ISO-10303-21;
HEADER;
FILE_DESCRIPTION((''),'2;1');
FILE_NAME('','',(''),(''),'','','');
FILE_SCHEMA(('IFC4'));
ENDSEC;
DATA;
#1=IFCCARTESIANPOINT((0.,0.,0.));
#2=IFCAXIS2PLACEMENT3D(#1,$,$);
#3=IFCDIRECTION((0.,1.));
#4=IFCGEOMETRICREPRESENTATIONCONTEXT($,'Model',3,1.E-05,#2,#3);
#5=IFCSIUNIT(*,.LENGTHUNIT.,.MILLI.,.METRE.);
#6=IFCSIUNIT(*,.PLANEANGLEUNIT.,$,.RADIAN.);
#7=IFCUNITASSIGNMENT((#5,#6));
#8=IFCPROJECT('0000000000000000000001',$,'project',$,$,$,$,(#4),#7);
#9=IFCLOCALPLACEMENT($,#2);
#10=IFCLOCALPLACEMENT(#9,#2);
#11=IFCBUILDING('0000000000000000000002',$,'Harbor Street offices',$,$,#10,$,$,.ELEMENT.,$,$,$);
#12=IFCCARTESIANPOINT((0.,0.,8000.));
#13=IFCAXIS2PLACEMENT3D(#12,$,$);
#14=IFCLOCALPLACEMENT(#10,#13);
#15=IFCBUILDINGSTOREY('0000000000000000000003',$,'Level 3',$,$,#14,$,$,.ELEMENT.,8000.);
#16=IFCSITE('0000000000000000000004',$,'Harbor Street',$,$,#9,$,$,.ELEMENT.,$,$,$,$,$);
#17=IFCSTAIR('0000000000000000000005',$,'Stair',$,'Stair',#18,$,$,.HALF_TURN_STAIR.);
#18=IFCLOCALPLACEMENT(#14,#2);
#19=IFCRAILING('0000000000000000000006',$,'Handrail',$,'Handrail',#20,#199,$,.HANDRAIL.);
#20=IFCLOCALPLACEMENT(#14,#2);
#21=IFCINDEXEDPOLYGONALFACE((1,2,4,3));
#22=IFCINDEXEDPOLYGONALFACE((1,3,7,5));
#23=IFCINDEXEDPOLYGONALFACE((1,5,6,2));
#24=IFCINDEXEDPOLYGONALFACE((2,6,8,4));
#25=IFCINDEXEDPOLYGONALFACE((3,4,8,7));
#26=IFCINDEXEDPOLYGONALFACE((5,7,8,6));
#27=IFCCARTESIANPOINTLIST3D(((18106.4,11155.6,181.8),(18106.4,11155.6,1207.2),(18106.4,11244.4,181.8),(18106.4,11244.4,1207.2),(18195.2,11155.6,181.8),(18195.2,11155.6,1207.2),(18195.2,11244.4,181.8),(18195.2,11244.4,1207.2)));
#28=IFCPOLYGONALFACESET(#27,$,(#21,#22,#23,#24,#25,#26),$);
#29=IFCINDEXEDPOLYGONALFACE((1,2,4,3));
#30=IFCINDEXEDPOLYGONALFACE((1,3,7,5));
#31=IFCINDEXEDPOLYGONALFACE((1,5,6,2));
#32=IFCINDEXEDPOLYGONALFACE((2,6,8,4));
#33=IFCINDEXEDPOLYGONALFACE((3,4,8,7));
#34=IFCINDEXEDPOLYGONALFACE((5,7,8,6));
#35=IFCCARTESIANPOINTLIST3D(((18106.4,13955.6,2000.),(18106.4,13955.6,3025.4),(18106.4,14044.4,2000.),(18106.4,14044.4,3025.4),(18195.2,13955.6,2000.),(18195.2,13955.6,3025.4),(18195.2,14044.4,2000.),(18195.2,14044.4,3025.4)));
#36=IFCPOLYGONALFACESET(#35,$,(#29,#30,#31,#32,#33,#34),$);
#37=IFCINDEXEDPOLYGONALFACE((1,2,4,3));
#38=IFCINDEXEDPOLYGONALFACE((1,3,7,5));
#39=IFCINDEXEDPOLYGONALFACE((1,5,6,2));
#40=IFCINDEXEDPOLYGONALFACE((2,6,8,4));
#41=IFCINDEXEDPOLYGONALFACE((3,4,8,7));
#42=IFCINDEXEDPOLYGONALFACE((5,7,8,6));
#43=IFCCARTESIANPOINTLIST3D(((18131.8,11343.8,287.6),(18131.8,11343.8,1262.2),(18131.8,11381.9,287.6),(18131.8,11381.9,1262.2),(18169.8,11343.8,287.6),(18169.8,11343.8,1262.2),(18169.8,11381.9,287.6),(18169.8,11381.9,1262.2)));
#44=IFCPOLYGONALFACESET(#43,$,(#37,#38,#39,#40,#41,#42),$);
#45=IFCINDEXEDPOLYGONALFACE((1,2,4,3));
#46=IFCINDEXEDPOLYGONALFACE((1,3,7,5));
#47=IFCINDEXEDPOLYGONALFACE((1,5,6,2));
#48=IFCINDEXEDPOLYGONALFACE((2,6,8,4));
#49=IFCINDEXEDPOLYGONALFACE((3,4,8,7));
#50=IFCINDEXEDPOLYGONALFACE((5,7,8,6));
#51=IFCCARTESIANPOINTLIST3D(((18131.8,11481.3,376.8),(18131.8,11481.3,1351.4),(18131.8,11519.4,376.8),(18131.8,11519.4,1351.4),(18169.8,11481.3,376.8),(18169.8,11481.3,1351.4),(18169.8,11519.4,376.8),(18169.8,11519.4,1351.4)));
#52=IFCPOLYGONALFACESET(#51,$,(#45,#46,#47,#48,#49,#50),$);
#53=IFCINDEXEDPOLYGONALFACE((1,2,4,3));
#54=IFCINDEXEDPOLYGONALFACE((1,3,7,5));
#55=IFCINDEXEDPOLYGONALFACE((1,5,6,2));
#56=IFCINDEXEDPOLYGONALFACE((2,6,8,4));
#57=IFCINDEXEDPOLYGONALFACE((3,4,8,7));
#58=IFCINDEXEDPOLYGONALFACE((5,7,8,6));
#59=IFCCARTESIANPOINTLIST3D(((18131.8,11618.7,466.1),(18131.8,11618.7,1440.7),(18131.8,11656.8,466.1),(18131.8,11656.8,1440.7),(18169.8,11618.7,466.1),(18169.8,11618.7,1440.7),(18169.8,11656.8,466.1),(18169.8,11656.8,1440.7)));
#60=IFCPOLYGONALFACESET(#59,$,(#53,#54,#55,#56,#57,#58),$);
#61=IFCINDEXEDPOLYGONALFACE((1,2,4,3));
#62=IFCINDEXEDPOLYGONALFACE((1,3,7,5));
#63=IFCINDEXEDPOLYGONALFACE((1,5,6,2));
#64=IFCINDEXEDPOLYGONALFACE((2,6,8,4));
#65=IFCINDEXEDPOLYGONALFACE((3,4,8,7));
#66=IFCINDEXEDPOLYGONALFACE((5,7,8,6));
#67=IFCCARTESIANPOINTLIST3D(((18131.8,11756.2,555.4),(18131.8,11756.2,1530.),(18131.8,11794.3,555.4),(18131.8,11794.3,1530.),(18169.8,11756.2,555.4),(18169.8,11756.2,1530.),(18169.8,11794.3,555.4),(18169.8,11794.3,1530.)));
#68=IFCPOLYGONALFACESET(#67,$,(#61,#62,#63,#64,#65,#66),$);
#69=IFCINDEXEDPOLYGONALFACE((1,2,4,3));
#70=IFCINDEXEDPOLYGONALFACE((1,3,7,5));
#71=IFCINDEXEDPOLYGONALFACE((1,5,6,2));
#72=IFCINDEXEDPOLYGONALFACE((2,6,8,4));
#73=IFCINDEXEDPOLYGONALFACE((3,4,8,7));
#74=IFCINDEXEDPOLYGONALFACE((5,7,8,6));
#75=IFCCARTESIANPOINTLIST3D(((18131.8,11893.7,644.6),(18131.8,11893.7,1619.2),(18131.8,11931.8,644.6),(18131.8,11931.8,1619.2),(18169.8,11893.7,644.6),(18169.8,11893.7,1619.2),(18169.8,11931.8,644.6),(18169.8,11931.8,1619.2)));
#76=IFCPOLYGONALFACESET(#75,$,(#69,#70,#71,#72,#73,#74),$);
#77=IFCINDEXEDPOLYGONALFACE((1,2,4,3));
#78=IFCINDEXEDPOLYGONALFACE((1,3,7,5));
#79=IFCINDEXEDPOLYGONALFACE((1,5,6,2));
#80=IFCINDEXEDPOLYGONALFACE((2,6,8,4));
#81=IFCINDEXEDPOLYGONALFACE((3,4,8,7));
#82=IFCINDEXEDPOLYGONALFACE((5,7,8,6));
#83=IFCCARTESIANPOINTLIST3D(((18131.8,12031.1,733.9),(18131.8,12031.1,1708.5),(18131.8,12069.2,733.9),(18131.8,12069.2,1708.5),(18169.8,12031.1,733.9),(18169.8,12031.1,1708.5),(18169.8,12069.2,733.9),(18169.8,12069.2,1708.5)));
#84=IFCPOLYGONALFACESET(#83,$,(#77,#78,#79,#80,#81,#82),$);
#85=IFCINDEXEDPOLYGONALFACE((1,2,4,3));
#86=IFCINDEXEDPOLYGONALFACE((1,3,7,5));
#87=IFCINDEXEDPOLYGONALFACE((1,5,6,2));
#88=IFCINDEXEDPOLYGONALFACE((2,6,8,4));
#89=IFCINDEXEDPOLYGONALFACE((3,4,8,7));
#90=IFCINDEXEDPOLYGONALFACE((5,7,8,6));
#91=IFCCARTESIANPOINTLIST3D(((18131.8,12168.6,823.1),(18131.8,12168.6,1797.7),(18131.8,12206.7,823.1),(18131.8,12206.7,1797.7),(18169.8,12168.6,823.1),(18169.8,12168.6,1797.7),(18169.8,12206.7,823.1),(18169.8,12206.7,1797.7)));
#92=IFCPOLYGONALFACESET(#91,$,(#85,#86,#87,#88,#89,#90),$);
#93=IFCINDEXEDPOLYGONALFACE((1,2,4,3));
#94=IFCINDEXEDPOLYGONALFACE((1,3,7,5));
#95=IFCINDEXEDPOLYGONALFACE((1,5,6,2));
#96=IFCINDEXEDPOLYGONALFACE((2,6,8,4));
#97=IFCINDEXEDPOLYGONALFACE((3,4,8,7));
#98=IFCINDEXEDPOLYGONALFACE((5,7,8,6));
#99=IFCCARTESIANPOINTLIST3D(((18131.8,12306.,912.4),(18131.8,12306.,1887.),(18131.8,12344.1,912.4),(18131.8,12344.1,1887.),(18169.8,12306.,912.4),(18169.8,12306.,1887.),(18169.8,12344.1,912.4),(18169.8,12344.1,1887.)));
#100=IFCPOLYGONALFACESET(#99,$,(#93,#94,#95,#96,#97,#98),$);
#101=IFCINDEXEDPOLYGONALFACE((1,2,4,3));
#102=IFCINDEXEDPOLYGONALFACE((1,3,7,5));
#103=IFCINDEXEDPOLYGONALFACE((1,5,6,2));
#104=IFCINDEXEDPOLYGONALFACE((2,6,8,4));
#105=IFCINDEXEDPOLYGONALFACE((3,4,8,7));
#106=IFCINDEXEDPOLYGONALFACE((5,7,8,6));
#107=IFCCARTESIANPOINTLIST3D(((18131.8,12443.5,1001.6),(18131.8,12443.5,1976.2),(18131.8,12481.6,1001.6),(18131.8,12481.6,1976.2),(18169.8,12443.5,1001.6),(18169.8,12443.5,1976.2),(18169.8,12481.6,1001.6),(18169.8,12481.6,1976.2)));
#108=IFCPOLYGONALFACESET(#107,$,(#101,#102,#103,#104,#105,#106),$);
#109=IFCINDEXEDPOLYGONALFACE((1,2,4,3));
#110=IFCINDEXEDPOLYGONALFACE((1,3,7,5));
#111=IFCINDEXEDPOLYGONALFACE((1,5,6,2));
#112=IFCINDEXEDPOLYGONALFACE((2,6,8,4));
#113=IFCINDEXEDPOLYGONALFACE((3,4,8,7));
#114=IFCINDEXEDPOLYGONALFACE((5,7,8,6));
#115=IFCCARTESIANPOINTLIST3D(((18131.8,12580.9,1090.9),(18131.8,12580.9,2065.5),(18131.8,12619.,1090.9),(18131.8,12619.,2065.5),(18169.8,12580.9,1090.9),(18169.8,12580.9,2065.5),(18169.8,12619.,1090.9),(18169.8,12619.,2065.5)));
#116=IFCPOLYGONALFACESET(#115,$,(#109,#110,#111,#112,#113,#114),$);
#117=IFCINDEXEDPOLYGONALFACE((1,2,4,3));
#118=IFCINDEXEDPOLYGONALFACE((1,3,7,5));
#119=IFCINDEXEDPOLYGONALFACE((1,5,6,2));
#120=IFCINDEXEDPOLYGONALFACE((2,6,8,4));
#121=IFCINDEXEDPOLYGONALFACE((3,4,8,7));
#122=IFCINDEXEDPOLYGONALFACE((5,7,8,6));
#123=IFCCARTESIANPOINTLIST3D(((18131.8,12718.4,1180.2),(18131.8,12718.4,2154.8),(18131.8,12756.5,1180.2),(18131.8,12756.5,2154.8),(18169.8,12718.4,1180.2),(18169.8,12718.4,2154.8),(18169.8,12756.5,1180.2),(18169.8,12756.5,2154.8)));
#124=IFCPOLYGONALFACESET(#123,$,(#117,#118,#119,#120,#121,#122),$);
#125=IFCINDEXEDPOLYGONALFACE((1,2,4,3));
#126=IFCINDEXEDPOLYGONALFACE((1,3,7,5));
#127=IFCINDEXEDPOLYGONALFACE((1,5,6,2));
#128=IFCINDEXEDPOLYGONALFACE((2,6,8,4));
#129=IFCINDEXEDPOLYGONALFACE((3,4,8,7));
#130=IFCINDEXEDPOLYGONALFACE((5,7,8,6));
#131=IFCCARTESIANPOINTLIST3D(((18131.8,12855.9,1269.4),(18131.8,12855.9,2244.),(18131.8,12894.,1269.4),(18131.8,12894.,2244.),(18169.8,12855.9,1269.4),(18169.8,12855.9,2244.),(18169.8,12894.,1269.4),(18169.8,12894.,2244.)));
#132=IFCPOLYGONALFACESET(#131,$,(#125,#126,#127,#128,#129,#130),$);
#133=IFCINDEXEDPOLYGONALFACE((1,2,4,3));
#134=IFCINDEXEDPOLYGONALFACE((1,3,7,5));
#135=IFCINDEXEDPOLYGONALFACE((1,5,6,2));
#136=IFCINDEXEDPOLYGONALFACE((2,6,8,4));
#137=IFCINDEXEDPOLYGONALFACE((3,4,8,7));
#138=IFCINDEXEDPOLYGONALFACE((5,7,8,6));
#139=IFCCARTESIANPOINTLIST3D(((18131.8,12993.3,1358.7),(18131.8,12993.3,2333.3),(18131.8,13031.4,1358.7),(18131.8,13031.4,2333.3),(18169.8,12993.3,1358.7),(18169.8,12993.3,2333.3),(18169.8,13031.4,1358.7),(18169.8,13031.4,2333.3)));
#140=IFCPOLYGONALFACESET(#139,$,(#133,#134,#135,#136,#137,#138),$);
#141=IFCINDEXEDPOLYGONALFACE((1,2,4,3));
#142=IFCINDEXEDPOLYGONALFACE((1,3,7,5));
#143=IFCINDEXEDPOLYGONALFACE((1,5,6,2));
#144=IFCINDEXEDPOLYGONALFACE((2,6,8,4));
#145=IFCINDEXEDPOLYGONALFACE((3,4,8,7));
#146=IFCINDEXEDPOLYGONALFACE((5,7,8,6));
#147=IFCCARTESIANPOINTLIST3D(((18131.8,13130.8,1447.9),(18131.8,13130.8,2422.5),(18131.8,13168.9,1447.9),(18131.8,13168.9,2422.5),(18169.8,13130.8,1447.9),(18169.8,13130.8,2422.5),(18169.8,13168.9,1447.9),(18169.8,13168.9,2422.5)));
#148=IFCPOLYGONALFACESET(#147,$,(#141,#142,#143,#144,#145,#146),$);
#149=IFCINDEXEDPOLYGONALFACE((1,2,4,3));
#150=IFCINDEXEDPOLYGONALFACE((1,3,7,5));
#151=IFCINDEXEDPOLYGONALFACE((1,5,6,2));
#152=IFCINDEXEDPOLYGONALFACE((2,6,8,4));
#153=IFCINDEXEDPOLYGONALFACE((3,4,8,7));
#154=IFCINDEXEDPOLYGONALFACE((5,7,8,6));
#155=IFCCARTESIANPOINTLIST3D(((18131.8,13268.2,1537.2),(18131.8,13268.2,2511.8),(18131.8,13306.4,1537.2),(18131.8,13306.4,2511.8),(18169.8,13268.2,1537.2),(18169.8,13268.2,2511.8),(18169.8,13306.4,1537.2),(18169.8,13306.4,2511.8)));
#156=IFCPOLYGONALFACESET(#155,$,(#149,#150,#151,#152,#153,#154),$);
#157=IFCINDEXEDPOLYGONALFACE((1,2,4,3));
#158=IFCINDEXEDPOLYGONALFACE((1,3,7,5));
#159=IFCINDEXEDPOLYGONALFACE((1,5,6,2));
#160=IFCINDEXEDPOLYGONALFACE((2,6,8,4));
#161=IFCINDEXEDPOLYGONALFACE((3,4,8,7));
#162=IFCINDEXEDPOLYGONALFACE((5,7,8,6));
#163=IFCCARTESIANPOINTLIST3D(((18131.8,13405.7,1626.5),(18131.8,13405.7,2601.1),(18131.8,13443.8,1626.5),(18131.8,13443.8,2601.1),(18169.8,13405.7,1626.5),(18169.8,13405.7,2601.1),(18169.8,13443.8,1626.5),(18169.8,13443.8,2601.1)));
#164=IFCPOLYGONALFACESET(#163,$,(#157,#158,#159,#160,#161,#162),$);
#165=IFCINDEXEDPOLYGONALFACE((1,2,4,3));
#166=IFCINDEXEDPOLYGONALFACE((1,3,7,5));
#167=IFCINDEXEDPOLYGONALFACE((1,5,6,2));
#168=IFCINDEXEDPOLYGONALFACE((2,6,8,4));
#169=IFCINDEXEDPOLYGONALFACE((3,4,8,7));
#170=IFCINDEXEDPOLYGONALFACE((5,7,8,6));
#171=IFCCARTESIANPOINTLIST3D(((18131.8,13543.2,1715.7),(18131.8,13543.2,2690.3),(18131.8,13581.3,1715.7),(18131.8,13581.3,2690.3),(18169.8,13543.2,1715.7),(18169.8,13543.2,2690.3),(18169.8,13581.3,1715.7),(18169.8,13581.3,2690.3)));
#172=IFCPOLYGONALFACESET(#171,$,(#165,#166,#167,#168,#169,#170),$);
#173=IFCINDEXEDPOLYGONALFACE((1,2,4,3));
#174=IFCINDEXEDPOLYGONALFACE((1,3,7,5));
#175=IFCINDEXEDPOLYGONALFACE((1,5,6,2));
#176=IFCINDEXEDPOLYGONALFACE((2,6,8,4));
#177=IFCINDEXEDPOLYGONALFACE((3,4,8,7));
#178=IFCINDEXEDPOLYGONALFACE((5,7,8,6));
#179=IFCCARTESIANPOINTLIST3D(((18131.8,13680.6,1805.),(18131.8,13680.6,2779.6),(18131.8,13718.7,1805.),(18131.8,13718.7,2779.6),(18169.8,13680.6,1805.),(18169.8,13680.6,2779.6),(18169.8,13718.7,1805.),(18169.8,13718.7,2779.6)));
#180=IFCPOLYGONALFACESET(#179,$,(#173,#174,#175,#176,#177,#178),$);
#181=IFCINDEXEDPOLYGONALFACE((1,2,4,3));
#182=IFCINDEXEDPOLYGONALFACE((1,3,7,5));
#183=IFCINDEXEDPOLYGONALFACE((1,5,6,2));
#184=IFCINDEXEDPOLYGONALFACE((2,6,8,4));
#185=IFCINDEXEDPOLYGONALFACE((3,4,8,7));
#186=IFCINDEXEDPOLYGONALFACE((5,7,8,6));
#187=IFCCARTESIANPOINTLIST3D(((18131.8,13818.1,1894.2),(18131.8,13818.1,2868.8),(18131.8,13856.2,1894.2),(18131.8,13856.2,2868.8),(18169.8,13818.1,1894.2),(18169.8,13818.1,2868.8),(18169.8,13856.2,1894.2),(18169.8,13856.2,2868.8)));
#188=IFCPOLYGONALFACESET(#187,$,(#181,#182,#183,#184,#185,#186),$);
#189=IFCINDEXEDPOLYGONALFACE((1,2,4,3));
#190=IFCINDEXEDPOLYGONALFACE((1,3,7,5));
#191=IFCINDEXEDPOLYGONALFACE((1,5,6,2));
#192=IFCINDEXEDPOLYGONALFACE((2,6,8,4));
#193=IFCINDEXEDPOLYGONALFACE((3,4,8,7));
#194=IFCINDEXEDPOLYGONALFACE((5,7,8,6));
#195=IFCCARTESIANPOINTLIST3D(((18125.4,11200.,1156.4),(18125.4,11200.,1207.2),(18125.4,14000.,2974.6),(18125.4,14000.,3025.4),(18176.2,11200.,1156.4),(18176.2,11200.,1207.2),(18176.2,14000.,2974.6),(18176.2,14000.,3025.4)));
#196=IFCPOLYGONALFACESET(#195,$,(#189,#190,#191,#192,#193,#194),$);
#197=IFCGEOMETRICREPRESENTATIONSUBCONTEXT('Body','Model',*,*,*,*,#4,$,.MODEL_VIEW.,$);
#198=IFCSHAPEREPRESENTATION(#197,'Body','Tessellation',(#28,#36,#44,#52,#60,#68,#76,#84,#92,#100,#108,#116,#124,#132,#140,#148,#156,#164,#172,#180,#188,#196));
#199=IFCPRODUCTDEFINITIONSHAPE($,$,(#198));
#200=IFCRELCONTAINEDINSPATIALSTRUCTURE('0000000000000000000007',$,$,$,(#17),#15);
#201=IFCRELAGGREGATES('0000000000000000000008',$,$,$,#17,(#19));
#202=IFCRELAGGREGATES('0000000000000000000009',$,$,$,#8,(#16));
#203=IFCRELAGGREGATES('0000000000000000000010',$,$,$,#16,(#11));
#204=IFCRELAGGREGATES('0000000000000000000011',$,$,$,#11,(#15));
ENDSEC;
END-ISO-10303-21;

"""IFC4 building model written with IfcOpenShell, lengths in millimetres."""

from ifc_helpers import new_model, si_unit, direction, frame, origin, origin_with_axes, place, context, subcontext, project, spatial, polyline, outline, extrude, element, aggregate, save


model = new_model("IFC4")

# Units and contexts
model_context = context("Model", 3, precision=1e-05, world=origin(), true_north=direction((0.0, 1.0)))
body_context = subcontext(model_context, "Body", "Model", "MODEL_VIEW")
ifc_project = project(units=[si_unit("LENGTHUNIT", "METRE", prefix="MILLI"), si_unit("PLANEANGLEUNIT", "RADIAN")], contexts=[model_context])

# Site, building, storey
site_placement = place(None, origin())
site = spatial("IfcSite", under=ifc_project, at=site_placement, Name="Harbor Street", CompositionType="ELEMENT")
building_placement = place(site_placement, origin())
building = spatial("IfcBuilding", under=site, at=building_placement, Name="Harbor Street offices", CompositionType="ELEMENT")
storey_placement = place(building_placement, frame((0.0, 0.0, 8000.0)))
storey = spatial("IfcBuildingStorey", under=building, at=storey_placement, Name="Level 3", CompositionType="ELEMENT", Elevation=8000.0)

# Stair
stair_placement = place(storey_placement, origin_with_axes())
stair = element("IfcStair", 1, at=stair_placement, inside=storey, Name="Stair", ObjectType="Stair", PredefinedType="HALF_TURN_STAIR")

# Railing
railing_1_placement = place(storey_placement, origin_with_axes())
railing_1 = element("IfcRailing", 2, at=railing_1_placement, Name="Handrail", ObjectType="Handrail", PredefinedType="HANDRAIL", context=body_context, shape_type="SweptSolid", body=[
    extrude(outline(polyline([(-44.5, -44.5), (44.5, -44.5), (44.5, 44.5), (-44.5, 44.5), (-44.5, -44.5)])), frame((18150.8, 11200.0, 181.8), z_axis=(0.0, 0.0, 1.0), x_axis=(1.0, 0.0, 0.0)), (0.0, 0.0, 1.0), 1025.4),
    extrude(outline(polyline([(-44.5, -44.5), (44.5, -44.5), (44.5, 44.5), (-44.5, 44.5), (-44.5, -44.5)])), frame((18150.8, 14000.0, 2000.0), z_axis=(0.0, 0.0, 1.0), x_axis=(1.0, 0.0, 0.0)), (0.0, 0.0, 1.0), 1025.4),
    extrude(outline(polyline([(-19.1, -19.1), (19.1, -19.1), (19.1, 19.1), (-19.1, 19.1), (-19.1, -19.1)])), frame((18150.8, 11362.9, 287.6), z_axis=(0.0, 0.0, 1.0), x_axis=(1.0, 0.0, 0.0)), (0.0, 0.0, 1.0), 974.6),
    extrude(outline(polyline([(-19.1, -19.1), (19.1, -19.1), (19.1, 19.1), (-19.1, 19.1), (-19.1, -19.1)])), frame((18150.8, 11500.3, 376.8), z_axis=(0.0, 0.0, 1.0), x_axis=(1.0, 0.0, 0.0)), (0.0, 0.0, 1.0), 974.6),
    extrude(outline(polyline([(-19.1, -19.1), (19.1, -19.1), (19.1, 19.1), (-19.1, 19.1), (-19.1, -19.1)])), frame((18150.8, 11637.8, 466.1), z_axis=(0.0, 0.0, 1.0), x_axis=(1.0, 0.0, 0.0)), (0.0, 0.0, 1.0), 974.6),
    extrude(outline(polyline([(-19.1, -19.1), (19.1, -19.1), (19.1, 19.1), (-19.1, 19.1), (-19.1, -19.1)])), frame((18150.8, 11775.2, 555.4), z_axis=(0.0, 0.0, 1.0), x_axis=(1.0, 0.0, 0.0)), (0.0, 0.0, 1.0), 974.6),
    extrude(outline(polyline([(-19.1, -19.1), (19.1, -19.1), (19.1, 19.1), (-19.1, 19.1), (-19.1, -19.1)])), frame((18150.8, 11912.7, 644.6), z_axis=(0.0, 0.0, 1.0), x_axis=(1.0, 0.0, 0.0)), (0.0, 0.0, 1.0), 974.6),
    extrude(outline(polyline([(-19.1, -19.1), (19.1, -19.1), (19.1, 19.1), (-19.1, 19.1), (-19.1, -19.1)])), frame((18150.8, 12050.2, 733.9), z_axis=(0.0, 0.0, 1.0), x_axis=(1.0, 0.0, 0.0)), (0.0, 0.0, 1.0), 974.6),
    extrude(outline(polyline([(-19.1, -19.1), (19.1, -19.1), (19.1, 19.1), (-19.1, 19.1), (-19.1, -19.1)])), frame((18150.8, 12187.6, 823.1), z_axis=(0.0, 0.0, 1.0), x_axis=(1.0, 0.0, 0.0)), (0.0, 0.0, 1.0), 974.6),
    extrude(outline(polyline([(-19.1, -19.1), (19.1, -19.1), (19.1, 19.1), (-19.1, 19.1), (-19.1, -19.1)])), frame((18150.8, 12325.1, 912.4), z_axis=(0.0, 0.0, 1.0), x_axis=(1.0, 0.0, 0.0)), (0.0, 0.0, 1.0), 974.6),
    extrude(outline(polyline([(-19.1, -19.1), (19.1, -19.1), (19.1, 19.1), (-19.1, 19.1), (-19.1, -19.1)])), frame((18150.8, 12462.5, 1001.6), z_axis=(0.0, 0.0, 1.0), x_axis=(1.0, 0.0, 0.0)), (0.0, 0.0, 1.0), 974.6),
    extrude(outline(polyline([(-19.1, -19.1), (19.1, -19.1), (19.1, 19.1), (-19.1, 19.1), (-19.1, -19.1)])), frame((18150.8, 12600.0, 1090.9), z_axis=(0.0, 0.0, 1.0), x_axis=(1.0, 0.0, 0.0)), (0.0, 0.0, 1.0), 974.6),
    extrude(outline(polyline([(-19.1, -19.1), (19.1, -19.1), (19.1, 19.1), (-19.1, 19.1), (-19.1, -19.1)])), frame((18150.8, 12737.5, 1180.2), z_axis=(0.0, 0.0, 1.0), x_axis=(1.0, 0.0, 0.0)), (0.0, 0.0, 1.0), 974.6),
    extrude(outline(polyline([(-19.1, -19.1), (19.1, -19.1), (19.1, 19.1), (-19.1, 19.1), (-19.1, -19.1)])), frame((18150.8, 12874.9, 1269.4), z_axis=(0.0, 0.0, 1.0), x_axis=(1.0, 0.0, 0.0)), (0.0, 0.0, 1.0), 974.6),
    extrude(outline(polyline([(-19.1, -19.1), (19.1, -19.1), (19.1, 19.1), (-19.1, 19.1), (-19.1, -19.1)])), frame((18150.8, 13012.4, 1358.7), z_axis=(0.0, 0.0, 1.0), x_axis=(1.0, 0.0, 0.0)), (0.0, 0.0, 1.0), 974.6),
    extrude(outline(polyline([(-19.1, -19.1), (19.1, -19.1), (19.1, 19.1), (-19.1, 19.1), (-19.1, -19.1)])), frame((18150.8, 13149.8, 1447.9), z_axis=(0.0, 0.0, 1.0), x_axis=(1.0, 0.0, 0.0)), (0.0, 0.0, 1.0), 974.6),
    extrude(outline(polyline([(-19.1, -19.1), (19.1, -19.1), (19.1, 19.1), (-19.1, 19.1), (-19.1, -19.1)])), frame((18150.8, 13287.3, 1537.2), z_axis=(0.0, 0.0, 1.0), x_axis=(1.0, 0.0, 0.0)), (0.0, 0.0, 1.0), 974.6),
    extrude(outline(polyline([(-19.1, -19.1), (19.1, -19.1), (19.1, 19.1), (-19.1, 19.1), (-19.1, -19.1)])), frame((18150.8, 13424.8, 1626.5), z_axis=(0.0, 0.0, 1.0), x_axis=(1.0, 0.0, 0.0)), (0.0, 0.0, 1.0), 974.6),
    extrude(outline(polyline([(-19.1, -19.1), (19.1, -19.1), (19.1, 19.1), (-19.1, 19.1), (-19.1, -19.1)])), frame((18150.8, 13562.2, 1715.7), z_axis=(0.0, 0.0, 1.0), x_axis=(1.0, 0.0, 0.0)), (0.0, 0.0, 1.0), 974.6),
    extrude(outline(polyline([(-19.1, -19.1), (19.1, -19.1), (19.1, 19.1), (-19.1, 19.1), (-19.1, -19.1)])), frame((18150.8, 13699.7, 1805.0), z_axis=(0.0, 0.0, 1.0), x_axis=(1.0, 0.0, 0.0)), (0.0, 0.0, 1.0), 974.6),
    extrude(outline(polyline([(-19.1, -19.1), (19.1, -19.1), (19.1, 19.1), (-19.1, 19.1), (-19.1, -19.1)])), frame((18150.8, 13837.1, 1894.2), z_axis=(0.0, 0.0, 1.0), x_axis=(1.0, 0.0, 0.0)), (0.0, 0.0, 1.0), 974.6),
    extrude(outline(polyline([(0.0, 0.0), (50.8, 0.0), (50.8, 50.8), (0.0, 50.8), (0.0, 0.0)])), frame((18176.2, 11200.0, 1156.4), z_axis=(0.0, 1.0, 0.0), x_axis=(-1.0, 0.0, 0.0)), (0.0, 0.544605, 0.838692), 3338.5),
])
aggregate(stair, [railing_1])

save(model, "model.ifc")
